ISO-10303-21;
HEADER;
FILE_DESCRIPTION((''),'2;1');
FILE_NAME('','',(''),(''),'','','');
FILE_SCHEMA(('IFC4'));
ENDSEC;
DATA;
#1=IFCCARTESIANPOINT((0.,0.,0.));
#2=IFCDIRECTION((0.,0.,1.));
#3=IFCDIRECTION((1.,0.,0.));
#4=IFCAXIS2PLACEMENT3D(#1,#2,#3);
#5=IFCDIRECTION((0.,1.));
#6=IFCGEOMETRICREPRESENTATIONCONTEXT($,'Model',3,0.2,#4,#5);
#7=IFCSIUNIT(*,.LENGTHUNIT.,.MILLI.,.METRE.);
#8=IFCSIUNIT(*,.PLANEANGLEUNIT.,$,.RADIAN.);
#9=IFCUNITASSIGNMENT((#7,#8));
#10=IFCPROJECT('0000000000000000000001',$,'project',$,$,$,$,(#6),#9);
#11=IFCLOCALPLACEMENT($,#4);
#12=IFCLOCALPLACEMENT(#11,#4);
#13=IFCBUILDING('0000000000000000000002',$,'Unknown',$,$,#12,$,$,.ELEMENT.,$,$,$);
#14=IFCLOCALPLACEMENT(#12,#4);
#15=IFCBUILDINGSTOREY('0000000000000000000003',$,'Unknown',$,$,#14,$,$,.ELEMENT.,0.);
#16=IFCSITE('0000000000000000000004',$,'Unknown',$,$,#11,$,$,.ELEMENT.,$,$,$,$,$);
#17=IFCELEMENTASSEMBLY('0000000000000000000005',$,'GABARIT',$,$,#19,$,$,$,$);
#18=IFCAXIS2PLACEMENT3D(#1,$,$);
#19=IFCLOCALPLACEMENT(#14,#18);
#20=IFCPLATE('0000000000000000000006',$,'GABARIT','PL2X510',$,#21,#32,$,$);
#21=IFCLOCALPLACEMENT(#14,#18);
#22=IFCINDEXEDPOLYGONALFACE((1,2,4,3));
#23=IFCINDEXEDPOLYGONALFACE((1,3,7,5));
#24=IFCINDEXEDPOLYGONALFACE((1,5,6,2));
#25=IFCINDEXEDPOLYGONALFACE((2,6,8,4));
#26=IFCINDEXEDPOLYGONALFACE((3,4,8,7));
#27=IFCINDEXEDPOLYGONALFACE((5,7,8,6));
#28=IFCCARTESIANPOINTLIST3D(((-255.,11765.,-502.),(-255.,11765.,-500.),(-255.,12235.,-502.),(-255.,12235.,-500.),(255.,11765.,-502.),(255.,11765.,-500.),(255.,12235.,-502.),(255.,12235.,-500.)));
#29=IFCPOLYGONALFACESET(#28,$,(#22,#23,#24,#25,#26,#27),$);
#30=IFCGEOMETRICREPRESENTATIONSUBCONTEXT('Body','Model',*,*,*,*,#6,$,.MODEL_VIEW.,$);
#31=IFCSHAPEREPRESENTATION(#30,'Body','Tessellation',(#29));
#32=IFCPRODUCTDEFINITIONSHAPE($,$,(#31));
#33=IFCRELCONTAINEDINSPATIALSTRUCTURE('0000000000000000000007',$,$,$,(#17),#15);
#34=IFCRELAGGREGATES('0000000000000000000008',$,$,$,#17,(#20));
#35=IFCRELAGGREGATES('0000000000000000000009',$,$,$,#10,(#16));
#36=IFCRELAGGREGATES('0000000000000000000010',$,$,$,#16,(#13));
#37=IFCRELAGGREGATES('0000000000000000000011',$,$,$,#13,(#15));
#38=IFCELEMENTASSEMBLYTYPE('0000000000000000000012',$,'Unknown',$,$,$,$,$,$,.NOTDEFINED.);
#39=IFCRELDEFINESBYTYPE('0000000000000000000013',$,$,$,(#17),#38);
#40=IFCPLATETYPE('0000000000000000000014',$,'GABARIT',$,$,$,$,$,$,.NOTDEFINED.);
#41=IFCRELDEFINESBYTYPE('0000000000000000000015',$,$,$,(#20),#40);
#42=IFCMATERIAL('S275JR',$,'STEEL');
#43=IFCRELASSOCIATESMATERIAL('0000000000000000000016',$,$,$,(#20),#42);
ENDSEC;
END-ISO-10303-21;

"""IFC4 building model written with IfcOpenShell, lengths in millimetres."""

from ifc_helpers import new_model, si_unit, direction, frame, origin_with_axes, origin_2d_with_axis, place, context, subcontext, project, spatial, rectangle, extrude, material, material_profile, profile_set, profile_usage, type_object, element, aggregate, save


model = new_model("IFC4")

# Units and contexts
model_context = context("Model", 3, precision=0.2, world=origin_with_axes(), true_north=direction((0.0, 1.0)))
body_context = subcontext(model_context, "Body", "Model", "MODEL_VIEW")
ifc_project = project(units=[si_unit("LENGTHUNIT", "METRE", prefix="MILLI"), si_unit("PLANEANGLEUNIT", "RADIAN")], contexts=[model_context])

# Site, building, storey
site_placement = place(None, origin_with_axes())
site = spatial("IfcSite", under=ifc_project, at=site_placement, Name="Unknown", CompositionType="ELEMENT")
building_placement = place(site_placement, origin_with_axes())
building = spatial("IfcBuilding", under=site, at=building_placement, Name="Unknown", CompositionType="ELEMENT")
storey_placement = place(building_placement, origin_with_axes())
storey = spatial("IfcBuildingStorey", under=building, at=storey_placement, Name="Unknown", CompositionType="ELEMENT", Elevation=0.0)

# Shared definitions
element_assembly_type = type_object("IfcElementAssemblyType", Name="Unknown", PredefinedType="NOTDEFINED")

# Shared definitions
ifc_material_1 = material(Name="S275JR", Category="STEEL")

# Element assembly, plate
assembly_1_placement = place(storey_placement, frame((0.0, 11765.0, -501.0), z_axis=(0.0, 0.0, 1.0), x_axis=(0.0, 1.0, 0.0)))
assembly_1 = element("IfcElementAssembly", 1, at=assembly_1_placement, inside=storey, type_object=element_assembly_type, Name="GABARIT")
ifc_material_profile_1 = material_profile(ifc_material_1, rectangle(XDim=470.0, YDim=510.0, at=origin_2d_with_axis()), Name="PL2X510")
ifc_profile_set_1 = profile_set([ifc_material_profile_1])
ifc_profile_usage_1 = profile_usage(ifc_profile_set_1, cardinal=2)
plate_type_1 = type_object("IfcPlateType", Name="GABARIT", PredefinedType="NOTDEFINED")
plate_1_placement = place(assembly_1_placement, frame((470.0, 0.0, 0.0), z_axis=(-1.0, 0.0, 0.0), x_axis=(0.0, 0.0, 1.0)))
plate_1 = element("IfcPlate", 2, at=plate_1_placement, type_object=plate_type_1, material=ifc_profile_usage_1, Name="GABARIT", Description="PL2X510", context=body_context, shape_type="SolidModel", body=[
    extrude(rectangle(XDim=470.0, YDim=510.0, at=origin_2d_with_axis()), frame((-1.0, 0.0, 235.0), z_axis=(-1.0, 0.0, 0.0), x_axis=(0.0, 0.0, 1.0)), (0.0, 0.0, -1.0), 2.0),
])
aggregate(assembly_1, [plate_1])

save(model, "model.ifc")
